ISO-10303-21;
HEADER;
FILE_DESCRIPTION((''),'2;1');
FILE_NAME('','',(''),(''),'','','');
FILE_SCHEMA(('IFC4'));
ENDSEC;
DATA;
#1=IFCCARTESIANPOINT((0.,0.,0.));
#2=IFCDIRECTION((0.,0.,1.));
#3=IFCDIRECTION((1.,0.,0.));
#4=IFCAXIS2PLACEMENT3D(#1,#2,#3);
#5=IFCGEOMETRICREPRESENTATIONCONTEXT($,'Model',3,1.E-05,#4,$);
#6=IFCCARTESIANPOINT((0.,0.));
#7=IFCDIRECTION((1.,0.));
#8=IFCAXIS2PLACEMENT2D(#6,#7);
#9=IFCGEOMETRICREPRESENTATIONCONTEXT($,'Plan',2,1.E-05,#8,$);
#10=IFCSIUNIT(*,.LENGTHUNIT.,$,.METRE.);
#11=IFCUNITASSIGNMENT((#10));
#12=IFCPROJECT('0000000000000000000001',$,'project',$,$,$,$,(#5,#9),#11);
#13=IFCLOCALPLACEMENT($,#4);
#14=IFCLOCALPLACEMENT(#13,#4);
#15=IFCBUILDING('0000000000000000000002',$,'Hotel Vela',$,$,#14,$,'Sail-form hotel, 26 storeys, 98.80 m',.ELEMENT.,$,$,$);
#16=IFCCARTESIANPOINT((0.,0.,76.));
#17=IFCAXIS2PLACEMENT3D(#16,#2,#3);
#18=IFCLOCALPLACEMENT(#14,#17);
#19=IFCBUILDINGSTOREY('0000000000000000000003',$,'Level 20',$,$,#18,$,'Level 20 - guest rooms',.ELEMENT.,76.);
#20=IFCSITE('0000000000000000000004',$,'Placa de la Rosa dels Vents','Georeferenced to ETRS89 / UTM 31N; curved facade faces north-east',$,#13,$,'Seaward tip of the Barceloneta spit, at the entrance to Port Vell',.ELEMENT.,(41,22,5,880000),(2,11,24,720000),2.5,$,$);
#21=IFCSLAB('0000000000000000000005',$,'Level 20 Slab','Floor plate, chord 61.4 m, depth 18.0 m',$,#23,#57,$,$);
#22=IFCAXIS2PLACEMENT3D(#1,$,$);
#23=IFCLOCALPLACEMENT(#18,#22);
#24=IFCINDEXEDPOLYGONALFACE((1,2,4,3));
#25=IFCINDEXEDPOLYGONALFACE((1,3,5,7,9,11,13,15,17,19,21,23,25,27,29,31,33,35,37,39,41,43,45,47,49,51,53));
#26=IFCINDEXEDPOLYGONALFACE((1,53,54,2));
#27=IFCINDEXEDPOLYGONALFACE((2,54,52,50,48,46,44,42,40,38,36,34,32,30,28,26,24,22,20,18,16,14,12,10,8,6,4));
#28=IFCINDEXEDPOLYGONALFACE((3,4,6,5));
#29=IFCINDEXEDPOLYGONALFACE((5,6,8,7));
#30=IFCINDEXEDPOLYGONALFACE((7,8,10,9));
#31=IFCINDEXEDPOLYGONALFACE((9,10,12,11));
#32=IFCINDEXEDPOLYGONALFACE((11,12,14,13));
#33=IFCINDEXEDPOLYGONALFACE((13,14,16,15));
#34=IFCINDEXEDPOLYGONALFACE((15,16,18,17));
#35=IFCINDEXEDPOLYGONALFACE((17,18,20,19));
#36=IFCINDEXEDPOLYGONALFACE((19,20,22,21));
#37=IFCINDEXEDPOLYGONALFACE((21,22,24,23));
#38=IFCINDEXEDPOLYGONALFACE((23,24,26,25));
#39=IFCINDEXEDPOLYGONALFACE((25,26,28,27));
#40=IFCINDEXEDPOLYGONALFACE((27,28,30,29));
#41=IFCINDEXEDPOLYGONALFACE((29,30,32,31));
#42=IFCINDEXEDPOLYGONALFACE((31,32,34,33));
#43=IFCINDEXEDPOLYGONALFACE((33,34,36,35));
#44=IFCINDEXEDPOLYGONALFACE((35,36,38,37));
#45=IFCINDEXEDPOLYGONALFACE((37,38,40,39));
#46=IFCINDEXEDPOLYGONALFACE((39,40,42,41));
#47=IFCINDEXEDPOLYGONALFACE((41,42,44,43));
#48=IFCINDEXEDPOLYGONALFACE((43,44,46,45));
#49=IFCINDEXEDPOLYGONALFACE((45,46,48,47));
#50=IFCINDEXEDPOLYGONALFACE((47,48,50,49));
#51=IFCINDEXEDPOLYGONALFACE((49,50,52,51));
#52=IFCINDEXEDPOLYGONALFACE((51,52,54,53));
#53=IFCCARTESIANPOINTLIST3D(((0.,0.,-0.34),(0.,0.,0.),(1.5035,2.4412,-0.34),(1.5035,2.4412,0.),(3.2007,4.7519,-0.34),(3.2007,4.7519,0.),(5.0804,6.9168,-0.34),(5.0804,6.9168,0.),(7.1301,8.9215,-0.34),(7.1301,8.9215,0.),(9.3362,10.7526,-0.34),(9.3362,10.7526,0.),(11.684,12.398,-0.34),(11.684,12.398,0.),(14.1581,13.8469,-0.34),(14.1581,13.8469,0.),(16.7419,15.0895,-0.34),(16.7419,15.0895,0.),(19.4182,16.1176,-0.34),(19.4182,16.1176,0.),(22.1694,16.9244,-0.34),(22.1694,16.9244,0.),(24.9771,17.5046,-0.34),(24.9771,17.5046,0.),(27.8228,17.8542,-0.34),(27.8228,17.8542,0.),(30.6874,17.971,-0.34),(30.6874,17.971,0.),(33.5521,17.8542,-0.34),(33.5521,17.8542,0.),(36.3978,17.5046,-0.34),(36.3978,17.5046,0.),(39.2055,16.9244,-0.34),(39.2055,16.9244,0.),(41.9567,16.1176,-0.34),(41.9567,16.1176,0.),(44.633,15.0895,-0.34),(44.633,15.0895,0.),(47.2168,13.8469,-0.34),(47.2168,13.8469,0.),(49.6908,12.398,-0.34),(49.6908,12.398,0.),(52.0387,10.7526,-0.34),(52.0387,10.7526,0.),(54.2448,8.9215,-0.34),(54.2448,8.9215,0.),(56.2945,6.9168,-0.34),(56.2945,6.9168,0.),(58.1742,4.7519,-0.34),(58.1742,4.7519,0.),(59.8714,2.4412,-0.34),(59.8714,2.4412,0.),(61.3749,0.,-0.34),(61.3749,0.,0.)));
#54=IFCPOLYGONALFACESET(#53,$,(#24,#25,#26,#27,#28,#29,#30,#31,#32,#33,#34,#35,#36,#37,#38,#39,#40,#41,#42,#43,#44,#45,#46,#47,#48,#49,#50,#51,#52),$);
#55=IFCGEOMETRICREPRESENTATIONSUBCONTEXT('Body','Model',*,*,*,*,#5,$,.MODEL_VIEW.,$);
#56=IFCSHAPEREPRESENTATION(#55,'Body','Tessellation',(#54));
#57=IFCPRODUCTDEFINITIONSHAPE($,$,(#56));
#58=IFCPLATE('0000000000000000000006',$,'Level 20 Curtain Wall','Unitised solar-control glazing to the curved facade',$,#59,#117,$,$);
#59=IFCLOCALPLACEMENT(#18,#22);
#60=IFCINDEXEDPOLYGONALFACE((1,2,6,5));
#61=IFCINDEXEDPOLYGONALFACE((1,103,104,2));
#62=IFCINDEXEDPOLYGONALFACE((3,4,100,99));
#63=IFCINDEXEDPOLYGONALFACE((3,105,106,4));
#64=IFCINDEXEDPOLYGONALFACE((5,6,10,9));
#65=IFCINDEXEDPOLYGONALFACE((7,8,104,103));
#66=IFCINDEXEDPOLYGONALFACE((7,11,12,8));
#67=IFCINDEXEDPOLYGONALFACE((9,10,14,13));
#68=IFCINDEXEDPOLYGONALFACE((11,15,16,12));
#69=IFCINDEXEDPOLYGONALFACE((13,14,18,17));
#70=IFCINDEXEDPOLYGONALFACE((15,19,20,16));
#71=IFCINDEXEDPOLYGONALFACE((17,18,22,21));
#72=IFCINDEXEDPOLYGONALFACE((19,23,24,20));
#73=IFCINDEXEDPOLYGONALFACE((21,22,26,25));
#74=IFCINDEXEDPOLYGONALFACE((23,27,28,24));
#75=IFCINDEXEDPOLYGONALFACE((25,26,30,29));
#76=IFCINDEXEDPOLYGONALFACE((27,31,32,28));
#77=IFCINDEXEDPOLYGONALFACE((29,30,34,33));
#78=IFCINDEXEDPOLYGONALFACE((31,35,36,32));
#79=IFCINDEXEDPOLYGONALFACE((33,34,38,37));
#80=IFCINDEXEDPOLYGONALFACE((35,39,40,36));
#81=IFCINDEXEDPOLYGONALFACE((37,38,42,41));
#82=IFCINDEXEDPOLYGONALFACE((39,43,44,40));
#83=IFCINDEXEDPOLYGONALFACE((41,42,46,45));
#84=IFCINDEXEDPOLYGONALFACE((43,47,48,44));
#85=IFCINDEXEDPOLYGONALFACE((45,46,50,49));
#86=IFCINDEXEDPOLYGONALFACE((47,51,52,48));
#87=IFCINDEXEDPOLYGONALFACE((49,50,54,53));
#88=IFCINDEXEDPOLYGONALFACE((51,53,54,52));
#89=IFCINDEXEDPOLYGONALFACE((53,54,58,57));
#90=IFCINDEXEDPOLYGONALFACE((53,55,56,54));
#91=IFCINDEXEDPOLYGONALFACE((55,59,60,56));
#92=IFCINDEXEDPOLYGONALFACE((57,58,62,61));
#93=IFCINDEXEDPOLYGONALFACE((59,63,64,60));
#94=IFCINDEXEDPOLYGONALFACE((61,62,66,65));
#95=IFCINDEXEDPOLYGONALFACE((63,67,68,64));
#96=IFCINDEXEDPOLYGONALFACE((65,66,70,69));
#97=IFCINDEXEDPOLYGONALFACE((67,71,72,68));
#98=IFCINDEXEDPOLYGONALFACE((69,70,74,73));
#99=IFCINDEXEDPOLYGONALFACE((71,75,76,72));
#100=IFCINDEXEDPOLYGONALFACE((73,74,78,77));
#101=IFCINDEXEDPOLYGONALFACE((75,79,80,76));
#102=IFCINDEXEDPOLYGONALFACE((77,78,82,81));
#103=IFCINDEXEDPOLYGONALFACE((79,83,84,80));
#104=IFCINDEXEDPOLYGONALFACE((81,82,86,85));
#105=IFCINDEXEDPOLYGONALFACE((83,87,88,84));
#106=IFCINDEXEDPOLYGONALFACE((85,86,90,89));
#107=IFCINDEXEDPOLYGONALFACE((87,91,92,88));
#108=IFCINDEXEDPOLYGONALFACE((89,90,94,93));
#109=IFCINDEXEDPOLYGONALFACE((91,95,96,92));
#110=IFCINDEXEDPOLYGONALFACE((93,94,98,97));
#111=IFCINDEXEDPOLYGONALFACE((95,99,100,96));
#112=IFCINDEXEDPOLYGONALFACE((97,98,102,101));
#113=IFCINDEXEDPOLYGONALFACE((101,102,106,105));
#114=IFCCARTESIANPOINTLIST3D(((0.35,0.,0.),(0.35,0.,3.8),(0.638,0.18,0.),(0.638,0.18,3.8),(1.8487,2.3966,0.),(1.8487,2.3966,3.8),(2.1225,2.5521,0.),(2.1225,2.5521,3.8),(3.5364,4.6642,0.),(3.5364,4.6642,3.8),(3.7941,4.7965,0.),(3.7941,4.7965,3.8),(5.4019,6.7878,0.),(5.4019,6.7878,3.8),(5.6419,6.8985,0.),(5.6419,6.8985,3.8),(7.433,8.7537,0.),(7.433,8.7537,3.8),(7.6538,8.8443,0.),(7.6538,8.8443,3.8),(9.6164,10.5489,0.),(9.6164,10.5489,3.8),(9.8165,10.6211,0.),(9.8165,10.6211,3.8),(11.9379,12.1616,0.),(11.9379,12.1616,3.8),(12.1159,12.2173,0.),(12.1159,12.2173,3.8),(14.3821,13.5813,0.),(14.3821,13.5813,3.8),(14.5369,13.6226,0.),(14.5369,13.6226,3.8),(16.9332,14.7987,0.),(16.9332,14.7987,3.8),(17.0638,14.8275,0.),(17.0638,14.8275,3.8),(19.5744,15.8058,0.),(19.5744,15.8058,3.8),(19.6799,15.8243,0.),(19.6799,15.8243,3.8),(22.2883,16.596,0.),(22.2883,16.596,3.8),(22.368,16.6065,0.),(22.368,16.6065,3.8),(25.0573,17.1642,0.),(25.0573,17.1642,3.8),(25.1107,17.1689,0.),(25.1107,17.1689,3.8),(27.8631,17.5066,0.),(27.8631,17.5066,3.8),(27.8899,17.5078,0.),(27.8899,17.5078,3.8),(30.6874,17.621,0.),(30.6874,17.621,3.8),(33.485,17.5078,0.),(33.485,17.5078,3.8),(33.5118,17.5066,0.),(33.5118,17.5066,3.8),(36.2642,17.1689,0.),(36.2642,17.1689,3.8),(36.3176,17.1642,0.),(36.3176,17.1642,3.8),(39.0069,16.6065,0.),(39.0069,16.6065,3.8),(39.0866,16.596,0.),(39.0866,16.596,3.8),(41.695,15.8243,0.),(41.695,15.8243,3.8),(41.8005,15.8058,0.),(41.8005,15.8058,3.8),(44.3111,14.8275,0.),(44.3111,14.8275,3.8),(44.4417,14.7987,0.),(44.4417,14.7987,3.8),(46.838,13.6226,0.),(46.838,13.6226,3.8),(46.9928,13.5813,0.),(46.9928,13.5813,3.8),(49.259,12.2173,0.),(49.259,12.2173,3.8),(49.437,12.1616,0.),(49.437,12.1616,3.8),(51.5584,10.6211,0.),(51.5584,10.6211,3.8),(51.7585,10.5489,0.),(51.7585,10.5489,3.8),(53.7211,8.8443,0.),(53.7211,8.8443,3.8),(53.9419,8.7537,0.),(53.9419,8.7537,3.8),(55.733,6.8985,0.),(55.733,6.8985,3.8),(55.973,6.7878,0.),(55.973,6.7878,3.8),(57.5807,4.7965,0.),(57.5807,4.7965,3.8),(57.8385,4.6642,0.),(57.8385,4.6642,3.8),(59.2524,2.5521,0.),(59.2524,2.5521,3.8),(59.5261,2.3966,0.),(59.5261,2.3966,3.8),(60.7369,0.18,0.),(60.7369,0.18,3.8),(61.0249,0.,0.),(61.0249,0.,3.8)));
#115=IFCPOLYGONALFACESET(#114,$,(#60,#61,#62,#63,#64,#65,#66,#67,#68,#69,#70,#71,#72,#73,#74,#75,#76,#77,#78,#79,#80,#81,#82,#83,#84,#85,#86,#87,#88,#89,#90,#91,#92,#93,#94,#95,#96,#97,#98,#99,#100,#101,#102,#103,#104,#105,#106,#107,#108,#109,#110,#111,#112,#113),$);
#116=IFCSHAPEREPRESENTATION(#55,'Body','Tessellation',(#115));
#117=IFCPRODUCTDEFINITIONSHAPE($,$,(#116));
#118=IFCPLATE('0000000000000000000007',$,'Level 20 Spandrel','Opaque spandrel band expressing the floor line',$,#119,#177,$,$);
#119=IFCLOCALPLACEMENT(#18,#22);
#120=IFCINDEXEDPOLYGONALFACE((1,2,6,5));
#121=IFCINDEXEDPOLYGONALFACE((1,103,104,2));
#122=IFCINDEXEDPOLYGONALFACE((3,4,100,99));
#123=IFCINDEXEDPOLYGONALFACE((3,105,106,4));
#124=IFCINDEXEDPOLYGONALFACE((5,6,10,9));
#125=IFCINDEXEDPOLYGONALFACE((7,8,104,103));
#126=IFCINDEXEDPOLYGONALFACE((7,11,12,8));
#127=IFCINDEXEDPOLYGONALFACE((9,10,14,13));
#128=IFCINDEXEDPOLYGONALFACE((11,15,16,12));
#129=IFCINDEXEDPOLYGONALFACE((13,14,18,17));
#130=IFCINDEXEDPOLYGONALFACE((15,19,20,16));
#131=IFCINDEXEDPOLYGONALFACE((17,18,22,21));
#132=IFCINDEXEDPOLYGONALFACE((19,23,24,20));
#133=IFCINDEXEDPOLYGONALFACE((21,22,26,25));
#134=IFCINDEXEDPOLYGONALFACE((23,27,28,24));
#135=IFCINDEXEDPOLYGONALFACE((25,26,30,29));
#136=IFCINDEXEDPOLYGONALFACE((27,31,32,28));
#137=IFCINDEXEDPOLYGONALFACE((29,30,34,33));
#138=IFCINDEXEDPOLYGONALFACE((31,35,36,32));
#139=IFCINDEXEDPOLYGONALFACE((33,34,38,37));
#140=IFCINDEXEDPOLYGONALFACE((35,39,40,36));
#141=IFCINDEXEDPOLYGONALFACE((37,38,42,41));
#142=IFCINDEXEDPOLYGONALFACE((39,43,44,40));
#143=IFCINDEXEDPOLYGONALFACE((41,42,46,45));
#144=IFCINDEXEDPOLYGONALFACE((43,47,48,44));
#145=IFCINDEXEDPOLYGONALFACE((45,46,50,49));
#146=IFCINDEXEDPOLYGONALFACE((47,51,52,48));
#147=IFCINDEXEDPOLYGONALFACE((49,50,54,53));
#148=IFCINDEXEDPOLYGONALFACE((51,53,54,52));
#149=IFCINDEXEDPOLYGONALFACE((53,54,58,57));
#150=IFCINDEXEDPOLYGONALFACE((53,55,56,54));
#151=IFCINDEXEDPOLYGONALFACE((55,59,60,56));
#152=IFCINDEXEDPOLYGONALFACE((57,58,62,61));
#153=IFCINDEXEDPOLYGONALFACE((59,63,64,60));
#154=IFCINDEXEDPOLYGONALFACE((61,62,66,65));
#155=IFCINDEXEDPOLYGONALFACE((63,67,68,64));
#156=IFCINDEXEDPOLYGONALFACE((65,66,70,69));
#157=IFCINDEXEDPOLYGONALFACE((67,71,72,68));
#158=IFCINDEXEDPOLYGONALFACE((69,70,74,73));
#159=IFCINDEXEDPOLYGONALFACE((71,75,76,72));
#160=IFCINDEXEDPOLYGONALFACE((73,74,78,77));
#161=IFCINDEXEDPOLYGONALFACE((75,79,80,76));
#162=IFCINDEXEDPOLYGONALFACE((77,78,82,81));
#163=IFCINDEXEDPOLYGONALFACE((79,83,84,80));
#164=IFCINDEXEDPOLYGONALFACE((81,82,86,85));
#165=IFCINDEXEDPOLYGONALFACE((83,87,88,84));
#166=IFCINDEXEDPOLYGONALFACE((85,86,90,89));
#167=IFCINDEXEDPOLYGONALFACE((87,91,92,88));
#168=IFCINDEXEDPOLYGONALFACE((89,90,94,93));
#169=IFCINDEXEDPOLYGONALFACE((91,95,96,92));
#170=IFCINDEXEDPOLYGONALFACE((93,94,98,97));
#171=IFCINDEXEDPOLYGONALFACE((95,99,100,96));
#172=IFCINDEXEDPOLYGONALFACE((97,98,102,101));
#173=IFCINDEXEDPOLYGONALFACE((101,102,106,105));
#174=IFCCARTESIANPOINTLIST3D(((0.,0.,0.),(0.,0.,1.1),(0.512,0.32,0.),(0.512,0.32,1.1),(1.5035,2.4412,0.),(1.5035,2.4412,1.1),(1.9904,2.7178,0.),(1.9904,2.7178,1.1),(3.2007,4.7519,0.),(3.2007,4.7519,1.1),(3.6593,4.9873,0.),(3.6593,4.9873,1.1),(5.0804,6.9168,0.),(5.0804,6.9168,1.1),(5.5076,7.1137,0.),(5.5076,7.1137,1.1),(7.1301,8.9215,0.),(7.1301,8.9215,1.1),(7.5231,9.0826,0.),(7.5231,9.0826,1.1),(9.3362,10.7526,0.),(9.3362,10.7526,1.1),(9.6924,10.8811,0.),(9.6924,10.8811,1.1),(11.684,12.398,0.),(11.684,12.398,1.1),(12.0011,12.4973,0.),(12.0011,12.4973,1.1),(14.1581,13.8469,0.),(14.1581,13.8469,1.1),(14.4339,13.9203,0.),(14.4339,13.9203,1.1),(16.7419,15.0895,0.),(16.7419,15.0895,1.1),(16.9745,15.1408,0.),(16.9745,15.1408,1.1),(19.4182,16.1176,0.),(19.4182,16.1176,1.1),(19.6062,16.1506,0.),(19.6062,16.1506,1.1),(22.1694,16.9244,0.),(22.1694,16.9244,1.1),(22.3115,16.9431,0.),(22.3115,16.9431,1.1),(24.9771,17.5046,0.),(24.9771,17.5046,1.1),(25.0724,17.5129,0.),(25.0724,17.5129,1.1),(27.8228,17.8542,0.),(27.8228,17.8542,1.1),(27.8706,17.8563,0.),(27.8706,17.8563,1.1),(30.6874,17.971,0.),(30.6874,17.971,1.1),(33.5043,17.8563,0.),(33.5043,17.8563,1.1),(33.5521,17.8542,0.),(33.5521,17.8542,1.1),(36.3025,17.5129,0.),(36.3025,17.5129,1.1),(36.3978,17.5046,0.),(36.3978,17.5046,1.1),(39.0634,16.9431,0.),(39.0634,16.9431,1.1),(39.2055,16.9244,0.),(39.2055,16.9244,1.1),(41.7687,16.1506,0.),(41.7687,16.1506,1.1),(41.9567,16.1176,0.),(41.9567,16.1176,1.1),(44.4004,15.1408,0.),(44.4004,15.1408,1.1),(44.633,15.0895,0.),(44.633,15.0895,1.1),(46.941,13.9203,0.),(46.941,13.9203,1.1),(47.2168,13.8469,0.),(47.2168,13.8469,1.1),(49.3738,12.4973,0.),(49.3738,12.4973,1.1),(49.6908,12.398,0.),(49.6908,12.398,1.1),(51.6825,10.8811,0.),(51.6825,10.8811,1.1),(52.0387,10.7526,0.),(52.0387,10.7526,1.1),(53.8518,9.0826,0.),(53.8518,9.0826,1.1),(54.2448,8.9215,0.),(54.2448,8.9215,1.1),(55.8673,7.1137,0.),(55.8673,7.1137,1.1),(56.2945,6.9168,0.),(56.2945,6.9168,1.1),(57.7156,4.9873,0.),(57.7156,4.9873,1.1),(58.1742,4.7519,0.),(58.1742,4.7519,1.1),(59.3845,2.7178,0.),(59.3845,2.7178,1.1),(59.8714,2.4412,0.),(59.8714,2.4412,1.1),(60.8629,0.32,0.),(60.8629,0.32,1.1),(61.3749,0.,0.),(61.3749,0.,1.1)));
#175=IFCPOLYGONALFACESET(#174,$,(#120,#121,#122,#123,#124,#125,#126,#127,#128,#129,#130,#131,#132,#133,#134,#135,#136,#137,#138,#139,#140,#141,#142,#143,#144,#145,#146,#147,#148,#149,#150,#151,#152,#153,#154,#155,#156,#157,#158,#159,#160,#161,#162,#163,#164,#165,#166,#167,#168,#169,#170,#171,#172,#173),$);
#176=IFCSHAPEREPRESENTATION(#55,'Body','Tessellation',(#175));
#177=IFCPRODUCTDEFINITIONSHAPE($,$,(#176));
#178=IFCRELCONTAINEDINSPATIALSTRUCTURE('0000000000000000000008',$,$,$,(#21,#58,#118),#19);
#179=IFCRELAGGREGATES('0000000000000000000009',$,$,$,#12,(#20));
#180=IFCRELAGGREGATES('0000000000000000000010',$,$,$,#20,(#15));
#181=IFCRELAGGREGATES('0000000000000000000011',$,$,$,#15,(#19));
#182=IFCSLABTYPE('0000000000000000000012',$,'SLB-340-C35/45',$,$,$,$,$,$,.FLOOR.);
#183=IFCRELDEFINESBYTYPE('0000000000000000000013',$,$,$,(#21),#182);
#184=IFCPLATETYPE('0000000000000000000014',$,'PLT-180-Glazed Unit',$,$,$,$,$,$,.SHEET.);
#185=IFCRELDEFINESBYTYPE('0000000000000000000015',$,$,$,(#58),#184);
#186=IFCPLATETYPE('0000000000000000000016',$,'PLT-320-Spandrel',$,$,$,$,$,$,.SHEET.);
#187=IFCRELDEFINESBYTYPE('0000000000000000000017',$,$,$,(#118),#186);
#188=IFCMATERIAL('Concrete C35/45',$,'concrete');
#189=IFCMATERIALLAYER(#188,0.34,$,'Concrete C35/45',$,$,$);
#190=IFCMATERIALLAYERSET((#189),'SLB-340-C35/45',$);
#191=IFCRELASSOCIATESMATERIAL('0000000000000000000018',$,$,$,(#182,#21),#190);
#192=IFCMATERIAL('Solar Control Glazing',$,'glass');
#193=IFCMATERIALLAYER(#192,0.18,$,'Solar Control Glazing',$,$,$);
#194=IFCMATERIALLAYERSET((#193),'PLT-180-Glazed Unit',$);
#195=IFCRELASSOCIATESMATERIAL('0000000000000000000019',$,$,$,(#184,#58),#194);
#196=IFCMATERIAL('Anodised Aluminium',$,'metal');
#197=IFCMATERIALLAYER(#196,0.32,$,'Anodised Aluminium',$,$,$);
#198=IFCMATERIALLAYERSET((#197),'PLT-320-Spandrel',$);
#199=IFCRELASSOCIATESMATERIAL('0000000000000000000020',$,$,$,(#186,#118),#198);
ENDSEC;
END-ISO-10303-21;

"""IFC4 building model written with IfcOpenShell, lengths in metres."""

from ifc_helpers import new_model, si_unit, frame, origin_with_axes, origin_2d_with_axis, place, context, subcontext, project, spatial, line, indexed_curve, outline, extrude, material, layer, layer_set, layer_usage, type_object, element, save


model = new_model("IFC4")

# Units and contexts
model_context = context("Model", 3, precision=1e-05, world=origin_with_axes())
plan_context = context("Plan", 2, precision=1e-05, world=origin_2d_with_axis())
body_context = subcontext(model_context, "Body", "Model", "MODEL_VIEW")
ifc_project = project(units=[si_unit("LENGTHUNIT", "METRE")], contexts=[model_context, plan_context])

# Site, building, storey
site_placement = place(None, origin_with_axes())
site = spatial("IfcSite", under=ifc_project, at=site_placement, Name="Placa de la Rosa dels Vents", Description="Georeferenced to ETRS89 / UTM 31N; curved facade faces north-east", LongName="Seaward tip of the Barceloneta spit, at the entrance to Port Vell", CompositionType="ELEMENT", RefLatitude=(41, 22, 5, 880000), RefLongitude=(2, 11, 24, 720000), RefElevation=2.5)
building_placement = place(site_placement, origin_with_axes())
building = spatial("IfcBuilding", under=site, at=building_placement, Name="Hotel Vela", LongName="Sail-form hotel, 26 storeys, 98.80 m", CompositionType="ELEMENT")
storey_placement = place(building_placement, frame((0.0, 0.0, 76.0), z_axis=(0.0, 0.0, 1.0), x_axis=(1.0, 0.0, 0.0)))
storey = spatial("IfcBuildingStorey", under=building, at=storey_placement, Name="Level 20", LongName="Level 20 - guest rooms", CompositionType="ELEMENT", Elevation=76.0)

# Slab
ifc_material_1 = material(Name="Concrete C35/45", Category="concrete")
ifc_layer_1 = layer(ifc_material_1, 0.34, Name="Concrete C35/45")
ifc_layer_set_1 = layer_set([ifc_layer_1], Name="SLB-340-C35/45")
ifc_layer_usage_1 = layer_usage(ifc_layer_set_1, "AXIS3", "POSITIVE", 0.0)
slab_type = type_object("IfcSlabType", Name="SLB-340-C35/45", PredefinedType="FLOOR", material=ifc_layer_set_1)
slab_placement = place(storey_placement, frame((0.0, 0.0, -0.34), z_axis=(0.0, 0.0, 1.0), x_axis=(1.0, 0.0, 0.0)))
element("IfcSlab", 1, at=slab_placement, inside=storey, type_object=slab_type, material=ifc_layer_usage_1, Name="Level 20 Slab", Description="Floor plate, chord 61.4 m, depth 18.0 m", context=body_context, shape_type="SweptSolid", body=[
    extrude(outline(indexed_curve([(0.0, 0.0), (61.3749, 0.0), (59.8714, 2.4412), (58.1742, 4.7519), (56.2945, 6.9168), (54.2448, 8.9215), (52.0387, 10.7526), (49.6908, 12.398), (47.2168, 13.8469), (44.633, 15.0895), (41.9567, 16.1176), (39.2055, 16.9244), (36.3978, 17.5046), (33.5521, 17.8542), (30.6874, 17.971), (27.8228, 17.8542), (24.9771, 17.5046), (22.1694, 16.9244), (19.4182, 16.1176), (16.7419, 15.0895), (14.1581, 13.8469), (11.684, 12.398), (9.3362, 10.7526), (7.1301, 8.9215), (5.0804, 6.9168), (3.2007, 4.7519), (1.5035, 2.4412)], segments=[line(1, 2, 3, 4, 5, 6, 7, 8, 9, 10, 11, 12, 13, 14, 15, 16, 17, 18, 19, 20, 21, 22, 23, 24, 25, 26, 27, 1)])), origin_with_axes(), (0.0, 0.0, 1.0), 0.34),
])

# Plates
ifc_material_2 = material(Name="Solar Control Glazing", Category="glass")
ifc_layer_2 = layer(ifc_material_2, 0.18, Name="Solar Control Glazing")
ifc_layer_set_2 = layer_set([ifc_layer_2], Name="PLT-180-Glazed Unit")
ifc_layer_usage_2 = layer_usage(ifc_layer_set_2, "AXIS2", "POSITIVE", 0.0)
plate_type_1 = type_object("IfcPlateType", Name="PLT-180-Glazed Unit", PredefinedType="SHEET", material=ifc_layer_set_2)
plate_1_placement = place(storey_placement, frame((0.35, 0.0, 0.0), z_axis=(0.0, 0.0, 1.0), x_axis=(1.0, 0.0, 0.0)))
element("IfcPlate", 2, at=plate_1_placement, inside=storey, type_object=plate_type_1, material=ifc_layer_usage_2, Name="Level 20 Curtain Wall", Description="Unitised solar-control glazing to the curved facade", context=body_context, shape_type="SweptSolid", body=[
    extrude(outline(indexed_curve([(60.6749, 0.0), (59.1761, 2.3966), (57.4885, 4.6642), (55.623, 6.7878), (53.5919, 8.7537), (51.4085, 10.5489), (49.087, 12.1616), (46.6428, 13.5813), (44.0917, 14.7987), (41.4505, 15.8058), (38.7366, 16.596), (35.9676, 17.1642), (33.1618, 17.5066), (30.3374, 17.621), (27.5131, 17.5066), (24.7073, 17.1642), (21.9383, 16.596), (19.2244, 15.8058), (16.5832, 14.7987), (14.0321, 13.5813), (11.5879, 12.1616), (9.2664, 10.5489), (7.083, 8.7537), (5.0519, 6.7878), (3.1864, 4.6642), (1.4987, 2.3966), (0.0, 0.0), (60.3869, 0.18), (1.7725, 2.5521), (3.4441, 4.7965), (5.2919, 6.8985), (7.3038, 8.8443), (9.4665, 10.6211), (11.7659, 12.2173), (14.1869, 13.6226), (16.7138, 14.8275), (19.3299, 15.8243), (22.018, 16.6065), (24.7607, 17.1689), (27.5399, 17.5078), (30.3374, 17.621), (33.135, 17.5078), (35.9142, 17.1689), (38.6569, 16.6065), (41.345, 15.8243), (43.9611, 14.8275), (46.488, 13.6226), (48.909, 12.2173), (51.2084, 10.6211), (53.3711, 8.8443), (55.383, 6.8985), (57.2307, 4.7965), (58.9024, 2.5521), (0.288, 0.18)], segments=[line(1, 2, 3, 4, 5, 6, 7, 8, 9, 10, 11, 12, 13, 14, 15, 16, 17, 18, 19, 20, 21, 22, 23, 24, 25, 26, 27, 28, 29, 30, 31, 32, 33, 34, 35, 36, 37, 38, 39, 40, 41, 42, 43, 44, 45, 46, 47, 48, 49, 50, 51, 52, 53, 54, 1)])), origin_with_axes(), (0.0, 0.0, 1.0), 3.8),
])
ifc_material_3 = material(Name="Anodised Aluminium", Category="metal")
ifc_layer_3 = layer(ifc_material_3, 0.32, Name="Anodised Aluminium")
ifc_layer_set_3 = layer_set([ifc_layer_3], Name="PLT-320-Spandrel")
ifc_layer_usage_3 = layer_usage(ifc_layer_set_3, "AXIS2", "POSITIVE", 0.0)
plate_type_2 = type_object("IfcPlateType", Name="PLT-320-Spandrel", PredefinedType="SHEET", material=ifc_layer_set_3)
plate_2_placement = place(storey_placement, origin_with_axes())
element("IfcPlate", 3, at=plate_2_placement, inside=storey, type_object=plate_type_2, material=ifc_layer_usage_3, Name="Level 20 Spandrel", Description="Opaque spandrel band expressing the floor line", context=body_context, shape_type="SweptSolid", body=[
    extrude(outline(indexed_curve([(61.3749, 0.0), (59.8714, 2.4412), (58.1742, 4.7519), (56.2945, 6.9168), (54.2448, 8.9215), (52.0387, 10.7526), (49.6908, 12.398), (47.2168, 13.8469), (44.633, 15.0895), (41.9567, 16.1176), (39.2055, 16.9244), (36.3978, 17.5046), (33.5521, 17.8542), (30.6874, 17.971), (27.8228, 17.8542), (24.9771, 17.5046), (22.1694, 16.9244), (19.4182, 16.1176), (16.7419, 15.0895), (14.1581, 13.8469), (11.684, 12.398), (9.3362, 10.7526), (7.1301, 8.9215), (5.0804, 6.9168), (3.2007, 4.7519), (1.5035, 2.4412), (0.0, 0.0), (60.8629, 0.32), (1.9904, 2.7178), (3.6593, 4.9873), (5.5076, 7.1137), (7.5231, 9.0826), (9.6924, 10.8811), (12.0011, 12.4973), (14.4339, 13.9203), (16.9745, 15.1408), (19.6062, 16.1506), (22.3115, 16.9431), (25.0724, 17.5129), (27.8706, 17.8563), (30.6874, 17.971), (33.5043, 17.8563), (36.3025, 17.5129), (39.0634, 16.9431), (41.7687, 16.1506), (44.4004, 15.1408), (46.941, 13.9203), (49.3738, 12.4973), (51.6825, 10.8811), (53.8518, 9.0826), (55.8673, 7.1137), (57.7156, 4.9873), (59.3845, 2.7178), (0.512, 0.32)], segments=[line(1, 2, 3, 4, 5, 6, 7, 8, 9, 10, 11, 12, 13, 14, 15, 16, 17, 18, 19, 20, 21, 22, 23, 24, 25, 26, 27, 28, 29, 30, 31, 32, 33, 34, 35, 36, 37, 38, 39, 40, 41, 42, 43, 44, 45, 46, 47, 48, 49, 50, 51, 52, 53, 54, 1)])), origin_with_axes(), (0.0, 0.0, 1.0), 1.1),
])

save(model, "model.ifc")
